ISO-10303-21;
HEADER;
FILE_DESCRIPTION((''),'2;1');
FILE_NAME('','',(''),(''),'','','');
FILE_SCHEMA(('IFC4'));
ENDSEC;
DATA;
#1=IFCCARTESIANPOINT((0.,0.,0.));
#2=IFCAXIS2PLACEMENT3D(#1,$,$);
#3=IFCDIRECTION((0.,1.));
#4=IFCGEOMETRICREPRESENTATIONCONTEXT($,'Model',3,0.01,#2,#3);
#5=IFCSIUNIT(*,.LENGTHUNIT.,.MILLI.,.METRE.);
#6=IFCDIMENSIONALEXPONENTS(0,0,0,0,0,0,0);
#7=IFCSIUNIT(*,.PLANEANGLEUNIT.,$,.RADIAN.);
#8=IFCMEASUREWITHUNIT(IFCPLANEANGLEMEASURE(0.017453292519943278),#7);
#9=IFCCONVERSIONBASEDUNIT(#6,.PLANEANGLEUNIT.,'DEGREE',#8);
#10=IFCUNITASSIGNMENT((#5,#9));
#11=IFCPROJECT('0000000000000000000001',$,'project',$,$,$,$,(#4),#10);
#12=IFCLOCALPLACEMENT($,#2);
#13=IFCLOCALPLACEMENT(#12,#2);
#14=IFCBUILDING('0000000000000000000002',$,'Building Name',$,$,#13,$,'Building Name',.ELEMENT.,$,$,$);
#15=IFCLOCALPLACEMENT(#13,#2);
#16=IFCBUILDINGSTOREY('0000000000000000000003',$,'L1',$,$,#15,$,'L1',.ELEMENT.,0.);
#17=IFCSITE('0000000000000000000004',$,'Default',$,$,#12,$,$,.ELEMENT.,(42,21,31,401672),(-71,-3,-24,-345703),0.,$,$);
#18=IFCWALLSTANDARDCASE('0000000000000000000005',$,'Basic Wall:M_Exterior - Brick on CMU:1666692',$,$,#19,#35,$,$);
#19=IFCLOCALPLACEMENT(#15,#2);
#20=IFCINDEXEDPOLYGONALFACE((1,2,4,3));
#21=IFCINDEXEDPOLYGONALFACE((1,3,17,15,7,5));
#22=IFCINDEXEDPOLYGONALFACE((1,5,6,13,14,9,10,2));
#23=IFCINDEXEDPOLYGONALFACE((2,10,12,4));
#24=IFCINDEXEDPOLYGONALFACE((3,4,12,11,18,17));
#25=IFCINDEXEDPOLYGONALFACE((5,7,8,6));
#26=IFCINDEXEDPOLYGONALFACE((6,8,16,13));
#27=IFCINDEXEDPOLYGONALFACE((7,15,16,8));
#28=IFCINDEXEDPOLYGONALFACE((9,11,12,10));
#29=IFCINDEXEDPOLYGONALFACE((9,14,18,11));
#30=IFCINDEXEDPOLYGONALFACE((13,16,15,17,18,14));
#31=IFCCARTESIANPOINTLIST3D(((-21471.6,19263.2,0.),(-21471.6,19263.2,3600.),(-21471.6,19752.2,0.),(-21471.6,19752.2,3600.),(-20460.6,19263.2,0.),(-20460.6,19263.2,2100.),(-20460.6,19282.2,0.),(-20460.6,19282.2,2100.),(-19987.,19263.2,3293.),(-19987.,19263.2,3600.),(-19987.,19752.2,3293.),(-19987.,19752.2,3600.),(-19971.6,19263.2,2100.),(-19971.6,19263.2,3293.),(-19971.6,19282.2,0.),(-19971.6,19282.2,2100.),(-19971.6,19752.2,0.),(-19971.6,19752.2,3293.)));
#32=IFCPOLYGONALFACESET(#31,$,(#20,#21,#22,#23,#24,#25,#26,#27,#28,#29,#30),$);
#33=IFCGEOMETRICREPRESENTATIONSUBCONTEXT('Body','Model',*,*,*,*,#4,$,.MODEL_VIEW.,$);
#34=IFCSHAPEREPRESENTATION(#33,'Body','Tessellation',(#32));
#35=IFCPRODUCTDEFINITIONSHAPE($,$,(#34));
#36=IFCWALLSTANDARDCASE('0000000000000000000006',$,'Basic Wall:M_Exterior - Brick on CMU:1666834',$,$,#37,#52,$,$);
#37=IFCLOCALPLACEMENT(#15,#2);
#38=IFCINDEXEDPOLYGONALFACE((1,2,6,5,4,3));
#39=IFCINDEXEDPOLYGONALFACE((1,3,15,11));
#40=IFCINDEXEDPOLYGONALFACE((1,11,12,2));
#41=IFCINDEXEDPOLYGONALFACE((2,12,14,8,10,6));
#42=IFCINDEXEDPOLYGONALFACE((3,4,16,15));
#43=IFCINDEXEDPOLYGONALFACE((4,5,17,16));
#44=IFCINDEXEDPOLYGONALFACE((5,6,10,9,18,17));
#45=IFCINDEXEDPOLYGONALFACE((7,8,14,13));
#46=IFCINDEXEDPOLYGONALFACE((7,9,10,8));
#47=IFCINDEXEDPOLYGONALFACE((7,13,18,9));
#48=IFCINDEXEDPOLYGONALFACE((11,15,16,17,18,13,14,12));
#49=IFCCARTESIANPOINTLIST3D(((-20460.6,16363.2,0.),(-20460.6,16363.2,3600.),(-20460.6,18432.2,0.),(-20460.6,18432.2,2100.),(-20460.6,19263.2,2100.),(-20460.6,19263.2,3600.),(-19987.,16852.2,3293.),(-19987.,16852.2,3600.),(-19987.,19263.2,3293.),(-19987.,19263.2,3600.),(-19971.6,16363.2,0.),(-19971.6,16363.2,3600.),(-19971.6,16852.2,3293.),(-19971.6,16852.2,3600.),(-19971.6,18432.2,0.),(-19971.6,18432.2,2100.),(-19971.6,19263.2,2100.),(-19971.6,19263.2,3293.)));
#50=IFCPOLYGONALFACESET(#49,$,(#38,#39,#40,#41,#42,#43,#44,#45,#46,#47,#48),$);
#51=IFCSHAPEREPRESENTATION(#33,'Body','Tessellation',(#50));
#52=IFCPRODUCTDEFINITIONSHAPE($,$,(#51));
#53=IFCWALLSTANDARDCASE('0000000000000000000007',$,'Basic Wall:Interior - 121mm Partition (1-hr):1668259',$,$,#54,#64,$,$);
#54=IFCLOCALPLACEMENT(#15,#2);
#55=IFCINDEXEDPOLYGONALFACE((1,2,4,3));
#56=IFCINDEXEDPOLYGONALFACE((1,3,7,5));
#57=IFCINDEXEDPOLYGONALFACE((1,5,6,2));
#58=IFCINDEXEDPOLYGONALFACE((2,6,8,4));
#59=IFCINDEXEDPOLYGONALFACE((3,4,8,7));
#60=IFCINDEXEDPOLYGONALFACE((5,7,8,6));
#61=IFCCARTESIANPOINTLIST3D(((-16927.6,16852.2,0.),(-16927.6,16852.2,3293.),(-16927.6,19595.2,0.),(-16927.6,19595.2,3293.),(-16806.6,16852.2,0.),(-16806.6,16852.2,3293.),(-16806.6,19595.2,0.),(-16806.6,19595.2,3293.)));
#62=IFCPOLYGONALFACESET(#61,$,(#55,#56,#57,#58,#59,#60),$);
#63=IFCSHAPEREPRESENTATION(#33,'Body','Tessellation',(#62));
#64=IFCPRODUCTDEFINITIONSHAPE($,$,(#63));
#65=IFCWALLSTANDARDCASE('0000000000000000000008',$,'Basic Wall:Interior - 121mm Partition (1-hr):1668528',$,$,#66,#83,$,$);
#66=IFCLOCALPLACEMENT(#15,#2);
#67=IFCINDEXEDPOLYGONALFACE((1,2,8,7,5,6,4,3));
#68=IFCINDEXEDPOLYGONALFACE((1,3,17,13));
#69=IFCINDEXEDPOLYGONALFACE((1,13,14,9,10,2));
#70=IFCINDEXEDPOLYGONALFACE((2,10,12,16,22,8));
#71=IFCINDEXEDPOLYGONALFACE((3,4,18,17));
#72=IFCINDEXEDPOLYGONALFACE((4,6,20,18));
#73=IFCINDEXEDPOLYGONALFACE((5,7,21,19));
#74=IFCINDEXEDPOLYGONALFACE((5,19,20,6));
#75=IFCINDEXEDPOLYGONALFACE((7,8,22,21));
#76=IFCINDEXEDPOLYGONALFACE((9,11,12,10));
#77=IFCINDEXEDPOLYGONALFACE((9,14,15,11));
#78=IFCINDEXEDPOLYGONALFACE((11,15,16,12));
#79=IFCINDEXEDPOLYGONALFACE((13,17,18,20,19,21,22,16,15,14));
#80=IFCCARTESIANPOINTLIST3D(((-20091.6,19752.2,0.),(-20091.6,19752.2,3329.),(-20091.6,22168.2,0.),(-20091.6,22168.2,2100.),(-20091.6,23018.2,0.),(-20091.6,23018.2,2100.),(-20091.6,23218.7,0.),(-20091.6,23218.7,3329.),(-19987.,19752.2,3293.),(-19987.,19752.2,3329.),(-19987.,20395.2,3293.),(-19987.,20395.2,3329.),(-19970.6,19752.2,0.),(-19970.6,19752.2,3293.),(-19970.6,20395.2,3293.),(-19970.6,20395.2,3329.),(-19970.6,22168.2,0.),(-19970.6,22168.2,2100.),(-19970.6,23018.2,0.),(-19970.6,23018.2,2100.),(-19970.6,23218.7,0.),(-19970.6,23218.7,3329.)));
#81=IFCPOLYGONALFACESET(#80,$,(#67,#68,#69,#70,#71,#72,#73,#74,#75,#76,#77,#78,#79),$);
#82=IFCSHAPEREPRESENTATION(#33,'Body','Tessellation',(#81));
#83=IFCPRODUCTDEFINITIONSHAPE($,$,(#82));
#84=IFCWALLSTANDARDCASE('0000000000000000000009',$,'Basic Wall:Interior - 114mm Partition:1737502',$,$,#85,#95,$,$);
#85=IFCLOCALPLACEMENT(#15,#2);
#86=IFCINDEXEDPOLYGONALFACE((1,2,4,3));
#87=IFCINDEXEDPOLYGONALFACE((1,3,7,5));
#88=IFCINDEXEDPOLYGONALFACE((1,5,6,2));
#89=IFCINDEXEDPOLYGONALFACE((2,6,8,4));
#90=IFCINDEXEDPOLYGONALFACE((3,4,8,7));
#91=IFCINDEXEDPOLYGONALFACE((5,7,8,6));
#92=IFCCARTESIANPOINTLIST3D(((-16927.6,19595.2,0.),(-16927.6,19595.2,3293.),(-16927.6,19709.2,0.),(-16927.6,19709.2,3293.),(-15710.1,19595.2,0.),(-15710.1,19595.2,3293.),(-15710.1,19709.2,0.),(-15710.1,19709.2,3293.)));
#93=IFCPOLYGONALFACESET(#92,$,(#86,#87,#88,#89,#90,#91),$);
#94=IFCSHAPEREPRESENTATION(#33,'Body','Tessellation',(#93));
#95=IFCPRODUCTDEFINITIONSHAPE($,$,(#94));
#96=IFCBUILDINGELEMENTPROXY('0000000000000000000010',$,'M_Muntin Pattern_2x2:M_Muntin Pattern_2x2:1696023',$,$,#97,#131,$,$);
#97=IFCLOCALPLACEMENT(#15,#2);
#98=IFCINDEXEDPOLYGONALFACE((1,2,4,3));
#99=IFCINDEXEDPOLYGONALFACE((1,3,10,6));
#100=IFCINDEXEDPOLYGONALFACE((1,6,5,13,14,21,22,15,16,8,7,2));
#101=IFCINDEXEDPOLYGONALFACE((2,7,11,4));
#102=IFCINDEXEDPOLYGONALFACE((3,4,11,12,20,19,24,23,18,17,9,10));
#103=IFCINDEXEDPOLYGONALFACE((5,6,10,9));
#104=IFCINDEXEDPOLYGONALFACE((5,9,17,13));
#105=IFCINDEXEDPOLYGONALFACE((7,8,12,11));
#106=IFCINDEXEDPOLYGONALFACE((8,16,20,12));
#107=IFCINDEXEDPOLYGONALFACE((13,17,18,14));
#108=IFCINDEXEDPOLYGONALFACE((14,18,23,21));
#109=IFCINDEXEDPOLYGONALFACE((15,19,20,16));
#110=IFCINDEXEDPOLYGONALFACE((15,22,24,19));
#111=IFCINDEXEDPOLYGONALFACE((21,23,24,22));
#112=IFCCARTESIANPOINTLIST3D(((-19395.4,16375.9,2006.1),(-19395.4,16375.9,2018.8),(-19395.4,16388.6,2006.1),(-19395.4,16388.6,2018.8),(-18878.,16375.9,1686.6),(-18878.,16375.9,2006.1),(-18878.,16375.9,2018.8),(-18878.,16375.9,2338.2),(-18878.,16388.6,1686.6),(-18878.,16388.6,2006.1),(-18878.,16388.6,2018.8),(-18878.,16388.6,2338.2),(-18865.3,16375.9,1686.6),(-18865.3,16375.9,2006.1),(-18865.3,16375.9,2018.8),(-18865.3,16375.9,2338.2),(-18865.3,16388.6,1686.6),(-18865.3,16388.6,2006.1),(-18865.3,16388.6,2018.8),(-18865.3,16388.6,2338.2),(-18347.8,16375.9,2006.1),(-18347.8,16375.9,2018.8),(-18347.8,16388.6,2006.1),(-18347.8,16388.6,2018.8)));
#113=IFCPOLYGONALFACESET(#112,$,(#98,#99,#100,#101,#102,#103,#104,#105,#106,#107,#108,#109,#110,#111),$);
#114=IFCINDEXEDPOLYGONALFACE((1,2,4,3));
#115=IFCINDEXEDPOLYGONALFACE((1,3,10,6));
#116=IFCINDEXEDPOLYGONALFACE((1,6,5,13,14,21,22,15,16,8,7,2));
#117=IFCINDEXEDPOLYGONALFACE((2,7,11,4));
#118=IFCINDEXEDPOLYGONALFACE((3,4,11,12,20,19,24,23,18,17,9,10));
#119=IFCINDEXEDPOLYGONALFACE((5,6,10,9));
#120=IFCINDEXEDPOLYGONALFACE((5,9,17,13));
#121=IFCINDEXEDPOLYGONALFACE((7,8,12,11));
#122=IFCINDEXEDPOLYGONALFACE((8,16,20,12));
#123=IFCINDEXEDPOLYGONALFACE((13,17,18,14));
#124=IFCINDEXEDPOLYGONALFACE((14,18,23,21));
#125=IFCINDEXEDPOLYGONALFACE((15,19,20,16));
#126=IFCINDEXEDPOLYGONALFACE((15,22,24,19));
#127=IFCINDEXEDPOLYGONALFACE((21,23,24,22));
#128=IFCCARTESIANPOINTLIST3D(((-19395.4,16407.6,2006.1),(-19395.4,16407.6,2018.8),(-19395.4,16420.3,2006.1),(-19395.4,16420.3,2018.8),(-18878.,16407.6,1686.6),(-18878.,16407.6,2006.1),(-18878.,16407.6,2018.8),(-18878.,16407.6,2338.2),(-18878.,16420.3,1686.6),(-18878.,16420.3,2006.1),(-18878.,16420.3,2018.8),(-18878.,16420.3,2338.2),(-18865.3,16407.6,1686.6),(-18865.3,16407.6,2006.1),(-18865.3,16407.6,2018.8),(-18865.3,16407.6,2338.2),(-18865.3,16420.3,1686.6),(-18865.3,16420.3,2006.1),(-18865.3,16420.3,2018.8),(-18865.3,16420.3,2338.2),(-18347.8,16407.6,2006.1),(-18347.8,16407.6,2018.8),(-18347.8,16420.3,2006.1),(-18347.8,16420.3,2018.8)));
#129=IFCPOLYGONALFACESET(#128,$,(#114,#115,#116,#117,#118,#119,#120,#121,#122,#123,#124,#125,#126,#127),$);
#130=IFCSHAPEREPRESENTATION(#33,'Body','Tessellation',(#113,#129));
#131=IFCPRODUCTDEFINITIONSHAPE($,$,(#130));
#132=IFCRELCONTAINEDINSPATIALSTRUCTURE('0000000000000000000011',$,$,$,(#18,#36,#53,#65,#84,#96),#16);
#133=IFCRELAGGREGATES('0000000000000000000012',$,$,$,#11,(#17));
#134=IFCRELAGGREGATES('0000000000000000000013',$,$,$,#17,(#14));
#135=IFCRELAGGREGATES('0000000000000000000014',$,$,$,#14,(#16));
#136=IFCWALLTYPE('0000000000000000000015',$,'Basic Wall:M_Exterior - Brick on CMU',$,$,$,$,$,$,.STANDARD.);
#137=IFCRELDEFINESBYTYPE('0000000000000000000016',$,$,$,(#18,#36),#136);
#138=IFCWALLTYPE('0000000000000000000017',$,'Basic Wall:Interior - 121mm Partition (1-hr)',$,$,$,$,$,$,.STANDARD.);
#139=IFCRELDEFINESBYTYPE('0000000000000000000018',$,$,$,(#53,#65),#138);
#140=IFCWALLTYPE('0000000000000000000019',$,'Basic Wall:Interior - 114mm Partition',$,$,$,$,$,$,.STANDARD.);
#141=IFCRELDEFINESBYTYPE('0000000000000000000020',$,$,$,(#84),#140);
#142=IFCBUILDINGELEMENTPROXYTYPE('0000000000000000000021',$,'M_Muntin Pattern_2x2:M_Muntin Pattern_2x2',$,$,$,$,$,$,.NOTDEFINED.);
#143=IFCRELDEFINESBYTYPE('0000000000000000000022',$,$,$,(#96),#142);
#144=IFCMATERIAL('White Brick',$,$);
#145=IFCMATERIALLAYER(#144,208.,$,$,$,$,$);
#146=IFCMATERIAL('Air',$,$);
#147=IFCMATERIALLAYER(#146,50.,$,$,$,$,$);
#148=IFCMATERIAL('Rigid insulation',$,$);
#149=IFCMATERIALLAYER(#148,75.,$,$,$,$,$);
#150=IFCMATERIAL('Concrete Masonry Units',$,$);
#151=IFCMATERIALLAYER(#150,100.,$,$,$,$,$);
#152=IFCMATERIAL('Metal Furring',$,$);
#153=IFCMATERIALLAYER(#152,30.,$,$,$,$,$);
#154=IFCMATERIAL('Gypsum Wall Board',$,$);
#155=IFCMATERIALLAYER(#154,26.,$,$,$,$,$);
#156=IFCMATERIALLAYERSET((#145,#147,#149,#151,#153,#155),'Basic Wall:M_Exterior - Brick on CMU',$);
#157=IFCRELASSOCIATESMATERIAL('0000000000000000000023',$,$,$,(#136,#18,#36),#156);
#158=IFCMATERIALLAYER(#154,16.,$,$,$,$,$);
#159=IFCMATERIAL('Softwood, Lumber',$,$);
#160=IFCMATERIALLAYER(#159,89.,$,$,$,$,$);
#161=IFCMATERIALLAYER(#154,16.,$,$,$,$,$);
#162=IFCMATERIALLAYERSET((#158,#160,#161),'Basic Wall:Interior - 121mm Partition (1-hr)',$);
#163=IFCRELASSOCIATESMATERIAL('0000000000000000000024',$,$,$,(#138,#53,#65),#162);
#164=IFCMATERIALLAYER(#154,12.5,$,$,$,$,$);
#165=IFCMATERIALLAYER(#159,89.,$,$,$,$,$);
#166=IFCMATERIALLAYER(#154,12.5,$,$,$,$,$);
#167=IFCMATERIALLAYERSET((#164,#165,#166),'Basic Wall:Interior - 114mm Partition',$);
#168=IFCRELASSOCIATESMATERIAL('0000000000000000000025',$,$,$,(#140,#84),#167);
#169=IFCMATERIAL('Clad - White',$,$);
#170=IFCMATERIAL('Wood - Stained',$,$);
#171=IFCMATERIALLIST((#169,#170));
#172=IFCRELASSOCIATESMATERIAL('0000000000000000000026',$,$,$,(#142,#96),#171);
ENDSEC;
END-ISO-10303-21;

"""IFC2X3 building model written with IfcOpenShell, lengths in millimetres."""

from ifc_helpers import new_model, entity, si_unit, converted_unit, direction, frame, frame_2d, origin, place, context, subcontext, project, spatial, polyline, rectangle, outline, extrude, clip, bounded_halfspace, source, transform, mapped, material, material_list, layer, layer_set, layer_usage, type_object, type_shapes, element, save


model = new_model("IFC2X3")

# Units and contexts
model_context = context("Model", 3, precision=0.01, world=origin(), true_north=direction((0.0, 1.0)))
body_context = subcontext(model_context, "Body", "Model", "MODEL_VIEW")
ifc_project = project(units=[si_unit("LENGTHUNIT", "METRE", prefix="MILLI"), converted_unit("PLANEANGLEUNIT", "DEGREE", entity("IfcPlaneAngleMeasure", 0.017453292519943278), si_unit("PLANEANGLEUNIT", "RADIAN"), dimensions=[0, 0, 0, 0, 0, 0, 0])], contexts=[model_context])

# Site, building, storey
site_placement = place(None, origin())
site = spatial("IfcSite", under=ifc_project, at=site_placement, Name="Default", CompositionType="ELEMENT", RefLatitude=(42, 21, 31, 401672), RefLongitude=(-71, -3, -24, -345703), RefElevation=0.0)
building_placement = place(site_placement, origin())
building = spatial("IfcBuilding", under=site, at=building_placement, Name="Building Name", LongName="Building Name", CompositionType="ELEMENT")
storey_placement = place(building_placement, origin())
storey = spatial("IfcBuildingStorey", under=building, at=storey_placement, Name="L1", LongName="L1", CompositionType="ELEMENT", Elevation=0.0)

# Walls, openings
ifc_material_1 = material(Name="White Brick")
ifc_layer_1 = layer(ifc_material_1, 208.0)
ifc_material_2 = material(Name="Air")
ifc_layer_2 = layer(ifc_material_2, 50.0)
ifc_material_3 = material(Name="Rigid insulation")
ifc_layer_3 = layer(ifc_material_3, 75.0)
ifc_material_4 = material(Name="Concrete Masonry Units")
ifc_layer_4 = layer(ifc_material_4, 100.0)
ifc_material_5 = material(Name="Metal Furring")
ifc_layer_5 = layer(ifc_material_5, 30.0)
ifc_material_6 = material(Name="Gypsum Wall Board")
ifc_layer_6 = layer(ifc_material_6, 26.0)
ifc_layer_set_1 = layer_set([ifc_layer_1, ifc_layer_2, ifc_layer_3, ifc_layer_4, ifc_layer_5, ifc_layer_6], Name="Basic Wall:M_Exterior - Brick on CMU")
ifc_layer_usage_1 = layer_usage(ifc_layer_set_1, "AXIS2", "POSITIVE", -244.5)
wall_type_1 = type_object("IfcWallType", Name="Basic Wall:M_Exterior - Brick on CMU", PredefinedType="STANDARD", material=ifc_layer_set_1)
wall_1_placement = place(storey_placement, frame((-21471.6, 19507.7, 0.0)))
wall_1 = element("IfcWallStandardCase", 1, at=wall_1_placement, inside=storey, type_object=wall_type_1, material=ifc_layer_usage_1, Name="Basic Wall:M_Exterior - Brick on CMU:1666692", context=body_context, shape_type="Clipping", body=[
    clip(extrude(rectangle(XDim=1500.0, YDim=489.0, at=frame_2d((750.0, 0.0), x_axis=(-1.0, 0.0))), origin(), (0.0, 0.0, 1.0), 3600.0), bounded_halfspace(frame((1484.6, -244.5, 3293.0), z_axis=(0.0, 0.0, -1.0), x_axis=(0.0, -1.0, 0.0)), True, frame((1484.6, -244.5, 3293.0)), polyline([(0.0, 0.0), (15.4, 0.0), (15.4, 489.0), (0.0, 489.0), (0.0, 0.0)]))),
])
opening_1_placement = place(wall_1_placement, origin())
element("IfcOpeningElement", 2, at=opening_1_placement, cuts=wall_1, ObjectType="Opening", context=body_context, shape_type="SweptSolid", body=[
    extrude(rectangle(XDim=2100.0, YDim=489.0, at=frame_2d((0.0, 0.0), x_axis=(0.0, 1.0))), frame((1255.5, -1075.5, 1050.0), z_axis=(0.0, 1.0, 0.0), x_axis=(-1.0, 0.0, 0.0)), (0.0, 0.0, 1.0), 850.0),
])
ifc_layer_usage_2 = layer_usage(ifc_layer_set_1, "AXIS2", "POSITIVE", -244.5)
wall_2_placement = place(storey_placement, frame((-20216.1, 19263.2, 0.0), z_axis=(0.0, 0.0, 1.0), x_axis=(0.0, -1.0, 0.0)))
wall_2 = element("IfcWallStandardCase", 3, at=wall_2_placement, inside=storey, type_object=wall_type_1, material=ifc_layer_usage_2, Name="Basic Wall:M_Exterior - Brick on CMU:1666834", context=body_context, shape_type="Clipping", body=[
    clip(extrude(rectangle(XDim=2900.0, YDim=489.0, at=frame_2d((1450.0, 0.0), x_axis=(-1.0, 0.0))), origin(), (0.0, 0.0, 1.0), 3600.0), bounded_halfspace(frame((2411.0, 244.5, 3293.0), z_axis=(0.0, 0.0, -1.0), x_axis=(1.0, 0.0, 0.0)), True, frame((2411.0, 244.5, 3293.0)), polyline([(0.0, 0.0), (-2411.0, 0.0), (-2411.0, -15.4), (0.0, -15.4), (0.0, 0.0)]))),
])
opening_2_placement = place(wall_2_placement, frame((831.0, 244.5, 0.0)))
element("IfcOpeningElement", 4, at=opening_2_placement, cuts=wall_2, ObjectType="Opening", context=body_context, shape_type="SweptSolid", body=[
    extrude(rectangle(XDim=2100.0, YDim=850.0, at=frame_2d((1050.0, 425.0), x_axis=(1.0, 0.0))), frame((0.0, 0.0, 0.0), z_axis=(0.0, -1.0, 0.0), x_axis=(0.0, 0.0, 1.0)), (0.0, 0.0, 1.0), 489.0),
])

# Shared definitions
ifc_material_7 = material(Name="Wood - Stained")

# Wall
ifc_layer_7 = layer(ifc_material_6, 16.0)
ifc_material_8 = material(Name="Softwood, Lumber")
ifc_layer_8 = layer(ifc_material_8, 89.0)
ifc_layer_9 = layer(ifc_material_6, 16.0)
ifc_layer_set_2 = layer_set([ifc_layer_7, ifc_layer_8, ifc_layer_9], Name="Basic Wall:Interior - 121mm Partition (1-hr)")
ifc_layer_usage_3 = layer_usage(ifc_layer_set_2, "AXIS2", "NEGATIVE", 60.5)
wall_type_2 = type_object("IfcWallType", Name="Basic Wall:Interior - 121mm Partition (1-hr)", PredefinedType="STANDARD", material=ifc_layer_set_2)
wall_3_placement = place(storey_placement, frame((-16867.1, 16852.2, 0.0), z_axis=(0.0, 0.0, 1.0), x_axis=(0.0, 1.0, 0.0)))
element("IfcWallStandardCase", 5, at=wall_3_placement, inside=storey, type_object=wall_type_2, material=ifc_layer_usage_3, Name="Basic Wall:Interior - 121mm Partition (1-hr):1668259", context=body_context, shape_type="Clipping", body=[
    clip(extrude(rectangle(XDim=2743.0, YDim=121.0, at=frame_2d((1371.5, 0.0), x_axis=(-1.0, 0.0))), origin(), (0.0, 0.0, 1.0), 3293.0), bounded_halfspace(frame((0.0, -60.5, 3293.0), z_axis=(0.0, 0.0, -1.0), x_axis=(-1.0, 0.0, 0.0)), True, frame((0.0, -60.5, 3293.0)), polyline([(0.0, 0.0), (2743.0, 0.0), (2743.0, 121.0), (0.0, 121.0), (0.0, 0.0)]))),
])

# Wall, opening
ifc_layer_usage_4 = layer_usage(ifc_layer_set_2, "AXIS2", "NEGATIVE", 60.5)
wall_4_placement = place(storey_placement, frame((-20031.1, 19752.2, 0.0), z_axis=(0.0, 0.0, 1.0), x_axis=(0.0, 1.0, 0.0)))
wall_4 = element("IfcWallStandardCase", 6, at=wall_4_placement, inside=storey, type_object=wall_type_2, material=ifc_layer_usage_4, Name="Basic Wall:Interior - 121mm Partition (1-hr):1668528", context=body_context, shape_type="Clipping", body=[
    clip(clip(extrude(rectangle(XDim=121.0, YDim=3466.5, at=frame_2d((1733.3, 0.0), x_axis=(0.0, 1.0))), origin(), (0.0, 0.0, 1.0), 3329.0), bounded_halfspace(frame((0.0, -60.5, 3293.0), z_axis=(0.0, 0.0, -1.0), x_axis=(-1.0, 0.0, 0.0)), True, frame((0.0, -60.5, 3293.0)), polyline([(0.0, 0.0), (643.0, 0.0), (643.0, 16.4), (0.0, 16.4), (0.0, 1.0), (0.0, 0.0)]))), bounded_halfspace(frame((643.0, -60.5, 3329.0), z_axis=(0.0, 0.0, -1.0), x_axis=(-1.0, 0.0, 0.0)), True, frame((643.0, -60.5, 3329.0)), polyline([(0.0, 0.0), (2823.5, 0.0), (2823.5, 16.4), (2823.5, 90.0), (2823.5, 121.0), (-643.0, 121.0), (-643.0, 16.4), (0.0, 16.4), (0.0, 0.0)]))),
])
opening_3_placement = place(wall_4_placement, frame((3266.0, 60.5, 0.0)))
element("IfcOpeningElement", 7, at=opening_3_placement, cuts=wall_4, ObjectType="Opening", context=body_context, shape_type="SweptSolid", body=[
    extrude(rectangle(XDim=2100.0, YDim=850.0, at=frame_2d((1050.0, 425.0), x_axis=(1.0, 0.0))), frame((0.0, 0.0, 0.0), z_axis=(0.0, -1.0, 0.0), x_axis=(0.0, 0.0, 1.0)), (0.0, 0.0, 1.0), 121.0),
])

# Wall
ifc_layer_10 = layer(ifc_material_6, 12.5)
ifc_layer_11 = layer(ifc_material_8, 89.0)
ifc_layer_12 = layer(ifc_material_6, 12.5)
ifc_layer_set_3 = layer_set([ifc_layer_10, ifc_layer_11, ifc_layer_12], Name="Basic Wall:Interior - 114mm Partition")
ifc_layer_usage_5 = layer_usage(ifc_layer_set_3, "AXIS2", "NEGATIVE", 57.0)
wall_type_3 = type_object("IfcWallType", Name="Basic Wall:Interior - 114mm Partition", PredefinedType="STANDARD", material=ifc_layer_set_3)
wall_5_placement = place(storey_placement, frame((-16927.6, 19652.2, 0.0)))
element("IfcWallStandardCase", 8, at=wall_5_placement, inside=storey, type_object=wall_type_3, material=ifc_layer_usage_5, Name="Basic Wall:Interior - 114mm Partition:1737502", context=body_context, shape_type="Clipping", body=[
    clip(extrude(rectangle(XDim=1217.5, YDim=114.0, at=frame_2d((608.8, 0.0), x_axis=(-1.0, 0.0))), origin(), (0.0, 0.0, 1.0), 3293.0), bounded_halfspace(frame((0.0, -57.0, 3293.0), z_axis=(0.0, 0.0, -1.0), x_axis=(0.0, -1.0, 0.0)), True, frame((0.0, -57.0, 3293.0)), polyline([(0.0, 0.0), (121.0, 0.0), (1217.5, 0.0), (1217.5, 114.0), (1103.5, 114.0), (0.0, 114.0), (0.0, 0.0)]))),
])

# Building element proxy
ifc_material_9 = material(Name="Clad - White")
ifc_material_list_1 = material_list([ifc_material_9, ifc_material_7])
building_element_proxy_type_1 = type_object("IfcBuildingElementProxyType", Name="M_Muntin Pattern_2x2:M_Muntin Pattern_2x2", PredefinedType="NOTDEFINED", material=ifc_material_list_1)
shared_shape_1 = source(origin(), body_context, "Body", "SweptSolid", [
    extrude(outline(polyline([(6.4, -6.4), (325.8, -6.4), (325.8, 6.3), (6.4, 6.3), (6.4, 523.8), (-6.3, 523.8), (-6.3, 6.3), (-325.8, 6.3), (-325.8, -6.4), (-6.3, -6.4), (-6.3, -523.8), (6.4, -523.8), (6.4, -6.4)])), frame((0.0, 9.5, 325.8), z_axis=(0.0, 1.0, 0.0), x_axis=(0.0, 0.0, 1.0)), (0.0, 0.0, 1.0), 12.7),
    extrude(outline(polyline([(6.4, -6.4), (325.8, -6.4), (325.8, 6.3), (6.4, 6.3), (6.4, 523.8), (-6.3, 523.8), (-6.3, 6.3), (-325.8, 6.3), (-325.8, -6.4), (-6.3, -6.4), (-6.3, -523.8), (6.4, -523.8), (6.4, -6.4)])), frame((0.0, -22.2, 325.8), z_axis=(0.0, 1.0, 0.0), x_axis=(0.0, 0.0, 1.0)), (0.0, 0.0, 1.0), 12.7),
])
type_shapes(building_element_proxy_type_1, [shared_shape_1])
for number, where, z_axis, x_axis, name in (
    (9, (-18871.6, 16398.1, 1686.6), (0.0, 0.0, 1.0), (-1.0, 0.0, 0.0), "M_Muntin Pattern_2x2:M_Muntin Pattern_2x2:1696023"),
):
    element("IfcBuildingElementProxy", number, at=place(storey_placement, frame(where, z_axis=z_axis, x_axis=x_axis)), inside=storey, type_object=building_element_proxy_type_1, material=ifc_material_list_1, Name=name, context=body_context, shape_type="MappedRepresentation", body=[
        mapped(shared_shape_1, transform((0.0, 0.0, 0.0), scale=1.0)),
    ])

save(model, "model.ifc")
